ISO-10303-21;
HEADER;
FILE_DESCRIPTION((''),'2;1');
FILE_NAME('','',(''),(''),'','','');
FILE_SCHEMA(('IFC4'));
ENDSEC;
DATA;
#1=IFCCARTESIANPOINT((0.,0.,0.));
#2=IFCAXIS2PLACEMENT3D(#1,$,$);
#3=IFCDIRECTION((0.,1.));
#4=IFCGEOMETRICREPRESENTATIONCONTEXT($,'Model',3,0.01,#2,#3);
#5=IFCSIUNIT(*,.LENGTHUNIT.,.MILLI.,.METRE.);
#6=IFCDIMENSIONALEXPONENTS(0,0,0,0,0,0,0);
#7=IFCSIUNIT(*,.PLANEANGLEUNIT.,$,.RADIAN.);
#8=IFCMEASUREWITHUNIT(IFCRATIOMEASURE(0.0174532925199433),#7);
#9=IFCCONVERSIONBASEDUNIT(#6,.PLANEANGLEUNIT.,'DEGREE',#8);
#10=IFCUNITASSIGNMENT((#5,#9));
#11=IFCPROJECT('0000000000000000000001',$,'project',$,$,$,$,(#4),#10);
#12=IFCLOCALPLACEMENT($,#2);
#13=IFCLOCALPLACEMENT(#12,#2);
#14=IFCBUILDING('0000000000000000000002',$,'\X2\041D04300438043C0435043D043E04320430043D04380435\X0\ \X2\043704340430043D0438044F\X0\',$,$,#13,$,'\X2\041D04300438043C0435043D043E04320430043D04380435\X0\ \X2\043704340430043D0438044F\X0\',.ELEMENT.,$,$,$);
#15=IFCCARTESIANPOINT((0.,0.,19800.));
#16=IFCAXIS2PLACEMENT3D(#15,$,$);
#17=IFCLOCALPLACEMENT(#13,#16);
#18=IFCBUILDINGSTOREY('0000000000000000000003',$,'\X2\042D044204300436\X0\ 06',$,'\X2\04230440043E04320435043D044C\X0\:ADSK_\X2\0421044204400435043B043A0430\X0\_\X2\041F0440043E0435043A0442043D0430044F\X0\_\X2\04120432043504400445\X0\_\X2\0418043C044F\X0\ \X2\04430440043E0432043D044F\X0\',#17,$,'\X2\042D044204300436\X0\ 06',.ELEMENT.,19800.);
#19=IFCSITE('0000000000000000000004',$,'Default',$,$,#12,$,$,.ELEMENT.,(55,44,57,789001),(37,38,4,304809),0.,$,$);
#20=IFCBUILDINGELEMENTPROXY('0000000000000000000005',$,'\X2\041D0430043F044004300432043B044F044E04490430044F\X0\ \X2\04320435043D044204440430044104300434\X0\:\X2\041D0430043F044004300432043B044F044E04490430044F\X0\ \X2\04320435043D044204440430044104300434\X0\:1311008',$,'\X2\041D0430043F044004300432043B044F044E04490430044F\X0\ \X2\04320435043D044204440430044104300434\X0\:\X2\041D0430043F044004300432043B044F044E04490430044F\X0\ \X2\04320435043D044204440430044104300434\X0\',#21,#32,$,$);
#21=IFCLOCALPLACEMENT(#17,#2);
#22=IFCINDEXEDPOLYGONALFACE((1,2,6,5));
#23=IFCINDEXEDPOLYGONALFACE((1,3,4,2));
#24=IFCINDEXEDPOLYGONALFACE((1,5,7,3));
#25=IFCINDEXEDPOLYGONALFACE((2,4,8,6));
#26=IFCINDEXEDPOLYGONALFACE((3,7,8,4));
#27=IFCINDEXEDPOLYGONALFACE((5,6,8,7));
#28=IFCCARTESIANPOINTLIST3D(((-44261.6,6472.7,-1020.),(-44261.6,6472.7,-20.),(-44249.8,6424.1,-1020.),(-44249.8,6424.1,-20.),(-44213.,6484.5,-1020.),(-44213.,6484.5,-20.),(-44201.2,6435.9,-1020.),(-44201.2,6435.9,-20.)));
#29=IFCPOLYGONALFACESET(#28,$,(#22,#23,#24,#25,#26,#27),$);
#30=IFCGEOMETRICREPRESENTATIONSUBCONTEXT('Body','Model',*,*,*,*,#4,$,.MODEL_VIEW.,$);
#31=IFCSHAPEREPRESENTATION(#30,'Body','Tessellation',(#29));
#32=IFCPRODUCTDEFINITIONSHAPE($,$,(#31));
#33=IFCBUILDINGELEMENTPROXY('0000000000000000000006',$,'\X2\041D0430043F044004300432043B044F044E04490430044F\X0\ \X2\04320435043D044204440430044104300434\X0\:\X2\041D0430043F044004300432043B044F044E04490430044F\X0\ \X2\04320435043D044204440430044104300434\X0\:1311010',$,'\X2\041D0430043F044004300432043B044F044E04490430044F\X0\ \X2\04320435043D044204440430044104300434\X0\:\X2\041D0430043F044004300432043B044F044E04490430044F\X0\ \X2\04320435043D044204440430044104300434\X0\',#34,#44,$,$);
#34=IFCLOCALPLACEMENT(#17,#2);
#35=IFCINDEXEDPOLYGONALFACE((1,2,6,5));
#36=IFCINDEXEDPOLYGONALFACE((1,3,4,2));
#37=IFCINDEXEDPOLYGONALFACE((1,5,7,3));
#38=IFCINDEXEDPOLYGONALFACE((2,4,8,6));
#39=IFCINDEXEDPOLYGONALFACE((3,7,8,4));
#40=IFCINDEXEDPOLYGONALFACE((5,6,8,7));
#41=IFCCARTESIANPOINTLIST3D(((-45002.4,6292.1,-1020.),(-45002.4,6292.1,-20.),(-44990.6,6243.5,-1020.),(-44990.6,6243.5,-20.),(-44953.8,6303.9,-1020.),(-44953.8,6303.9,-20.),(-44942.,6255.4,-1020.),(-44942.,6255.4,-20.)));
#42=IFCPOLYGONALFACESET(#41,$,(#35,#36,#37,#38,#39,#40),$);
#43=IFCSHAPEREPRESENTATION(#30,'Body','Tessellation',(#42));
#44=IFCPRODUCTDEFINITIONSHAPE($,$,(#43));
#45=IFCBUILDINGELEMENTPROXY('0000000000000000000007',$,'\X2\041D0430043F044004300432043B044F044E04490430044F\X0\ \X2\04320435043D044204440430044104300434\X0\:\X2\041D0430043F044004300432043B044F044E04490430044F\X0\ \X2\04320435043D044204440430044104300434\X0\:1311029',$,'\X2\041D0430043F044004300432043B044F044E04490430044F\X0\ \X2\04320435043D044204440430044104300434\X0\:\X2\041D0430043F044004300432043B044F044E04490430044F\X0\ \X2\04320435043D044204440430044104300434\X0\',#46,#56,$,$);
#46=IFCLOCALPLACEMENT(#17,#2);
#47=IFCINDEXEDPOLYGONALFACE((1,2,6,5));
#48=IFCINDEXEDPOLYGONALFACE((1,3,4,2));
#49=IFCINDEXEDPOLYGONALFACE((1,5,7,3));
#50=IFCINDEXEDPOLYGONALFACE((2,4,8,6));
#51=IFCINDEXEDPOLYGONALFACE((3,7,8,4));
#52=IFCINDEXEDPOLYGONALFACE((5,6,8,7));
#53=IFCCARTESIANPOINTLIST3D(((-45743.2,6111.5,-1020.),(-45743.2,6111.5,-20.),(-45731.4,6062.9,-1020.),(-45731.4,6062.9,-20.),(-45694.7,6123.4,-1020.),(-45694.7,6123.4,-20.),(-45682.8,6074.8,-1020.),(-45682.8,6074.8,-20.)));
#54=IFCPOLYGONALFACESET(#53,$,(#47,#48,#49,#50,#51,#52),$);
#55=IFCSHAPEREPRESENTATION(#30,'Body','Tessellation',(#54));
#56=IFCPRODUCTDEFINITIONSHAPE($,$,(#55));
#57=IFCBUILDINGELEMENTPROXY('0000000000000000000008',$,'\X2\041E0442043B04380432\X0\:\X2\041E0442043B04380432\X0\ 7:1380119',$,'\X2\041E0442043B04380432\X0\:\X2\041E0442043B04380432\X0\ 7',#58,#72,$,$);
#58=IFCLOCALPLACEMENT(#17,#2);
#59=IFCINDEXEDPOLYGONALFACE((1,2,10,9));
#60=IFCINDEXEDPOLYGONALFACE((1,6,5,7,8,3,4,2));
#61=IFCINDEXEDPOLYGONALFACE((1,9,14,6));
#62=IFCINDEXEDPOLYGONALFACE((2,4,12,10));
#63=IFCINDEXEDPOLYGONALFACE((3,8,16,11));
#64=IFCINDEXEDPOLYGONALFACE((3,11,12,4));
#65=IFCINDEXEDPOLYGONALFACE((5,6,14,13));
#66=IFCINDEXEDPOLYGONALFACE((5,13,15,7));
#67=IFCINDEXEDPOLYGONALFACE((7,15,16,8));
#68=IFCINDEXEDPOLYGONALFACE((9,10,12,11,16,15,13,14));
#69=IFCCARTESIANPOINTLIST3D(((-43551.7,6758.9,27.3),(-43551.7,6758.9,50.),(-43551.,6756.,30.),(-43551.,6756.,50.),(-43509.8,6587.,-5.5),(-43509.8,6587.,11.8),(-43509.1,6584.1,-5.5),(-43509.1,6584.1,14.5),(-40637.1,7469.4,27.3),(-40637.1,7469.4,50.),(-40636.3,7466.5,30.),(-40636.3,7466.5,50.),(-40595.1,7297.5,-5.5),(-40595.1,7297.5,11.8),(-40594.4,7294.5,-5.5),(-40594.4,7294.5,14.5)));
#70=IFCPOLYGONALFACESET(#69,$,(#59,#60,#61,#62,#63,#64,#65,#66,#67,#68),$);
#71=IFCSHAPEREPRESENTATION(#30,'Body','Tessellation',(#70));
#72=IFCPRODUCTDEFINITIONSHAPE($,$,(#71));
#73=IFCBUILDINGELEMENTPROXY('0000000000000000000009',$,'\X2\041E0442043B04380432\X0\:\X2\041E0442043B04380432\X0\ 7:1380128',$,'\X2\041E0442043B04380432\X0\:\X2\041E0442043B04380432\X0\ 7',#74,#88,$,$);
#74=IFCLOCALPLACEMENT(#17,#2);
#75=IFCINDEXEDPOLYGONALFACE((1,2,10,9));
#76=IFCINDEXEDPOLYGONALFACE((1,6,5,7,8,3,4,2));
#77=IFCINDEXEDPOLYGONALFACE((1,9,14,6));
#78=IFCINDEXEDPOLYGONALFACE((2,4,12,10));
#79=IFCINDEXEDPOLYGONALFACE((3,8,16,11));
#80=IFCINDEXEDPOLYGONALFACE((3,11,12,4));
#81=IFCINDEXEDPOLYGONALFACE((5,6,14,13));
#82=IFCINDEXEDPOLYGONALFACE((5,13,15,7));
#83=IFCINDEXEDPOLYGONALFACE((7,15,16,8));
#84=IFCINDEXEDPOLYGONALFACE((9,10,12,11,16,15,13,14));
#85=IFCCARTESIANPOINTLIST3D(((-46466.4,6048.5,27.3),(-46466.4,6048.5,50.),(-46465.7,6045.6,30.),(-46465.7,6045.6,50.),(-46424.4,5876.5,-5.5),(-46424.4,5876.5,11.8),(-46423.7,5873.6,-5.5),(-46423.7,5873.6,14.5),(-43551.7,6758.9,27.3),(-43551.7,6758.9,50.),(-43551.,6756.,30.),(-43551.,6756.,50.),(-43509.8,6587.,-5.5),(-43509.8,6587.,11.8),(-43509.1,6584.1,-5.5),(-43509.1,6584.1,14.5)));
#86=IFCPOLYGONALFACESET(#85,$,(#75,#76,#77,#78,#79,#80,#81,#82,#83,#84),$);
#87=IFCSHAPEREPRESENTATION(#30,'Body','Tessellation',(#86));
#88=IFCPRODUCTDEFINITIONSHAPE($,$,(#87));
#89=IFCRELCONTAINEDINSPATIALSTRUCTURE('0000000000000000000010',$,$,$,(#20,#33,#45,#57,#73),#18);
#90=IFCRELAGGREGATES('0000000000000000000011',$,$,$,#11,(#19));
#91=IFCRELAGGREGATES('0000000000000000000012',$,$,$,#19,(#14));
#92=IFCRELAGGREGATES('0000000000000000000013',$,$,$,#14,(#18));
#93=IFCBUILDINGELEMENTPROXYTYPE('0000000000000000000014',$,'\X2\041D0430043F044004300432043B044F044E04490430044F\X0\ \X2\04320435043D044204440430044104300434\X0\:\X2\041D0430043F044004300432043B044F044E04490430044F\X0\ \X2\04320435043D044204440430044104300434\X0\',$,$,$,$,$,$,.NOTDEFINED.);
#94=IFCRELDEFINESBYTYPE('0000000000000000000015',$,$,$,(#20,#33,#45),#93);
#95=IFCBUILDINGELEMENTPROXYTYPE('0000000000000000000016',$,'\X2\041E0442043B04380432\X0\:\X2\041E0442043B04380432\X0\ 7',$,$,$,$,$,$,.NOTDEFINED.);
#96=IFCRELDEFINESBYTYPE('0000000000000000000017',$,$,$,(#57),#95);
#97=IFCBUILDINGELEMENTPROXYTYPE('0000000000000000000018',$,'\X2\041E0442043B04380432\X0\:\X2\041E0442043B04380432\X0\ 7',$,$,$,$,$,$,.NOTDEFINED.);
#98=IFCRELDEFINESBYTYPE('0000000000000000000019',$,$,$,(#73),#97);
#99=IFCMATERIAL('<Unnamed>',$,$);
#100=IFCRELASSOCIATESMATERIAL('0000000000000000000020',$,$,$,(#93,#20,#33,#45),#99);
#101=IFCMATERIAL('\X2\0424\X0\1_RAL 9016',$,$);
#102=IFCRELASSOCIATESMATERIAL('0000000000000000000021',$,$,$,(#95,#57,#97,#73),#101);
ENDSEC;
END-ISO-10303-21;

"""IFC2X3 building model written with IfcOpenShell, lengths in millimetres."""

from ifc_helpers import new_model, entity, si_unit, converted_unit, direction, frame, origin, origin_2d_with_axis, place, context, subcontext, project, spatial, polyline, rectangle, outline, extrude, source, transform, mapped, material, type_object, type_shapes, element, save


model = new_model("IFC2X3")

# Units and contexts
model_context = context("Model", 3, precision=0.01, world=origin(), true_north=direction((0.0, 1.0)))
body_context = subcontext(model_context, "Body", "Model", "MODEL_VIEW")
ifc_project = project(units=[si_unit("LENGTHUNIT", "METRE", prefix="MILLI"), converted_unit("PLANEANGLEUNIT", "DEGREE", entity("IfcRatioMeasure", 0.0174532925199433), si_unit("PLANEANGLEUNIT", "RADIAN"), dimensions=[0, 0, 0, 0, 0, 0, 0])], contexts=[model_context])

# Site, building, storey
site_placement = place(None, origin())
site = spatial("IfcSite", under=ifc_project, at=site_placement, Name="Default", CompositionType="ELEMENT", RefLatitude=(55, 44, 57, 789001), RefLongitude=(37, 38, 4, 304809), RefElevation=0.0)
building_placement = place(site_placement, origin())
building = spatial("IfcBuilding", under=site, at=building_placement, Name="Наименование здания", LongName="Наименование здания", CompositionType="ELEMENT")
storey_placement = place(building_placement, frame((0.0, 0.0, 19800.0)))
storey = spatial("IfcBuildingStorey", under=building, at=storey_placement, Name="Этаж 06", ObjectType="Уровень:ADSK_Стрелка_Проектная_Вверх_Имя уровня", LongName="Этаж 06", CompositionType="ELEMENT", Elevation=19800.0)

# Shared definitions
ifc_material_1 = material(Name="<Unnamed>")

# Building element proxies
building_element_proxy_type_1 = type_object("IfcBuildingElementProxyType", Name="Направляющая вентфасад:Направляющая вентфасад", PredefinedType="NOTDEFINED", material=ifc_material_1)
shared_shape_1 = source(origin(), body_context, "Body", "SweptSolid", [
    extrude(rectangle(XDim=50.0, YDim=50.0, at=origin_2d_with_axis()), frame((25.0, -25.0, 0.0), z_axis=(0.0, 0.0, 1.0), x_axis=(-1.0, 0.0, 0.0)), (0.0, 0.0, 1.0), 1000.0),
])
type_shapes(building_element_proxy_type_1, [shared_shape_1])
for number, where, z_axis, x_axis, name in (
    (1, (-44261.6, 6472.7, -1020.0), (0.0, 0.0, 1.0), (0.971552, 0.236826, 0.0), "Направляющая вентфасад:Направляющая вентфасад:1311008"),
    (2, (-45002.4, 6292.1, -1020.0), (0.0, 0.0, 1.0), (0.971552, 0.236826, 0.0), "Направляющая вентфасад:Направляющая вентфасад:1311010"),
    (3, (-45743.2, 6111.5, -1020.0), (0.0, 0.0, 1.0), (0.971552, 0.236826, 0.0), "Направляющая вентфасад:Направляющая вентфасад:1311029"),
):
    element("IfcBuildingElementProxy", number, at=place(storey_placement, frame(where, z_axis=z_axis, x_axis=x_axis)), inside=storey, type_object=building_element_proxy_type_1, material=ifc_material_1, Name=name, ObjectType="Направляющая вентфасад:Направляющая вентфасад", context=body_context, shape_type="MappedRepresentation", body=[
        mapped(shared_shape_1, transform((0.0, 0.0, 0.0), scale=1.0)),
    ])
ifc_material_2 = material(Name="Ф1_RAL 9016")
building_element_proxy_type_2 = type_object("IfcBuildingElementProxyType", Name="Отлив:Отлив 7", PredefinedType="NOTDEFINED", material=ifc_material_2)
shared_shape_2 = source(origin(), body_context, "Body", "SweptSolid", [
    extrude(outline(polyline([(7.1, -90.0), (27.1, -90.0), (27.1, -87.0), (9.8, -87.0), (-5.7, 90.0), (-28.4, 90.0), (-28.4, 87.0), (-8.4, 87.0), (7.1, -90.0)])), frame((21.3, 87.4, 27.1), z_axis=(0.971552, 0.236826, 0.0), x_axis=(0.0, 0.0, -1.0)), (0.0, 0.0, 1.0), 3000.0),
])
type_shapes(building_element_proxy_type_2, [shared_shape_2])
proxy_1_placement = place(storey_placement, frame((-43551.7, 6584.1, -5.5)))
element("IfcBuildingElementProxy", 4, at=proxy_1_placement, inside=storey, type_object=building_element_proxy_type_2, material=ifc_material_2, Name="Отлив:Отлив 7:1380119", ObjectType="Отлив:Отлив 7", context=body_context, shape_type="MappedRepresentation", body=[
    mapped(shared_shape_2, transform((0.0, 0.0, 0.0), scale=1.0)),
])
building_element_proxy_type_3 = type_object("IfcBuildingElementProxyType", Name="Отлив:Отлив 7", PredefinedType="NOTDEFINED", material=ifc_material_2)
shared_shape_3 = source(origin(), body_context, "Body", "SweptSolid", [
    extrude(outline(polyline([(7.1, -90.0), (27.1, -90.0), (27.1, -87.0), (9.8, -87.0), (-5.7, 90.0), (-28.4, 90.0), (-28.4, 87.0), (-8.4, 87.0), (7.1, -90.0)])), frame((21.3, 87.4, 27.1), z_axis=(0.971552, 0.236826, 0.0), x_axis=(0.0, 0.0, -1.0)), (0.0, 0.0, 1.0), 3000.0),
])
type_shapes(building_element_proxy_type_3, [shared_shape_3])
proxy_2_placement = place(storey_placement, frame((-46466.4, 5873.6, -5.5)))
element("IfcBuildingElementProxy", 5, at=proxy_2_placement, inside=storey, type_object=building_element_proxy_type_3, material=ifc_material_2, Name="Отлив:Отлив 7:1380128", ObjectType="Отлив:Отлив 7", context=body_context, shape_type="MappedRepresentation", body=[
    mapped(shared_shape_3, transform((0.0, 0.0, 0.0), scale=1.0)),
])

save(model, "model.ifc")
